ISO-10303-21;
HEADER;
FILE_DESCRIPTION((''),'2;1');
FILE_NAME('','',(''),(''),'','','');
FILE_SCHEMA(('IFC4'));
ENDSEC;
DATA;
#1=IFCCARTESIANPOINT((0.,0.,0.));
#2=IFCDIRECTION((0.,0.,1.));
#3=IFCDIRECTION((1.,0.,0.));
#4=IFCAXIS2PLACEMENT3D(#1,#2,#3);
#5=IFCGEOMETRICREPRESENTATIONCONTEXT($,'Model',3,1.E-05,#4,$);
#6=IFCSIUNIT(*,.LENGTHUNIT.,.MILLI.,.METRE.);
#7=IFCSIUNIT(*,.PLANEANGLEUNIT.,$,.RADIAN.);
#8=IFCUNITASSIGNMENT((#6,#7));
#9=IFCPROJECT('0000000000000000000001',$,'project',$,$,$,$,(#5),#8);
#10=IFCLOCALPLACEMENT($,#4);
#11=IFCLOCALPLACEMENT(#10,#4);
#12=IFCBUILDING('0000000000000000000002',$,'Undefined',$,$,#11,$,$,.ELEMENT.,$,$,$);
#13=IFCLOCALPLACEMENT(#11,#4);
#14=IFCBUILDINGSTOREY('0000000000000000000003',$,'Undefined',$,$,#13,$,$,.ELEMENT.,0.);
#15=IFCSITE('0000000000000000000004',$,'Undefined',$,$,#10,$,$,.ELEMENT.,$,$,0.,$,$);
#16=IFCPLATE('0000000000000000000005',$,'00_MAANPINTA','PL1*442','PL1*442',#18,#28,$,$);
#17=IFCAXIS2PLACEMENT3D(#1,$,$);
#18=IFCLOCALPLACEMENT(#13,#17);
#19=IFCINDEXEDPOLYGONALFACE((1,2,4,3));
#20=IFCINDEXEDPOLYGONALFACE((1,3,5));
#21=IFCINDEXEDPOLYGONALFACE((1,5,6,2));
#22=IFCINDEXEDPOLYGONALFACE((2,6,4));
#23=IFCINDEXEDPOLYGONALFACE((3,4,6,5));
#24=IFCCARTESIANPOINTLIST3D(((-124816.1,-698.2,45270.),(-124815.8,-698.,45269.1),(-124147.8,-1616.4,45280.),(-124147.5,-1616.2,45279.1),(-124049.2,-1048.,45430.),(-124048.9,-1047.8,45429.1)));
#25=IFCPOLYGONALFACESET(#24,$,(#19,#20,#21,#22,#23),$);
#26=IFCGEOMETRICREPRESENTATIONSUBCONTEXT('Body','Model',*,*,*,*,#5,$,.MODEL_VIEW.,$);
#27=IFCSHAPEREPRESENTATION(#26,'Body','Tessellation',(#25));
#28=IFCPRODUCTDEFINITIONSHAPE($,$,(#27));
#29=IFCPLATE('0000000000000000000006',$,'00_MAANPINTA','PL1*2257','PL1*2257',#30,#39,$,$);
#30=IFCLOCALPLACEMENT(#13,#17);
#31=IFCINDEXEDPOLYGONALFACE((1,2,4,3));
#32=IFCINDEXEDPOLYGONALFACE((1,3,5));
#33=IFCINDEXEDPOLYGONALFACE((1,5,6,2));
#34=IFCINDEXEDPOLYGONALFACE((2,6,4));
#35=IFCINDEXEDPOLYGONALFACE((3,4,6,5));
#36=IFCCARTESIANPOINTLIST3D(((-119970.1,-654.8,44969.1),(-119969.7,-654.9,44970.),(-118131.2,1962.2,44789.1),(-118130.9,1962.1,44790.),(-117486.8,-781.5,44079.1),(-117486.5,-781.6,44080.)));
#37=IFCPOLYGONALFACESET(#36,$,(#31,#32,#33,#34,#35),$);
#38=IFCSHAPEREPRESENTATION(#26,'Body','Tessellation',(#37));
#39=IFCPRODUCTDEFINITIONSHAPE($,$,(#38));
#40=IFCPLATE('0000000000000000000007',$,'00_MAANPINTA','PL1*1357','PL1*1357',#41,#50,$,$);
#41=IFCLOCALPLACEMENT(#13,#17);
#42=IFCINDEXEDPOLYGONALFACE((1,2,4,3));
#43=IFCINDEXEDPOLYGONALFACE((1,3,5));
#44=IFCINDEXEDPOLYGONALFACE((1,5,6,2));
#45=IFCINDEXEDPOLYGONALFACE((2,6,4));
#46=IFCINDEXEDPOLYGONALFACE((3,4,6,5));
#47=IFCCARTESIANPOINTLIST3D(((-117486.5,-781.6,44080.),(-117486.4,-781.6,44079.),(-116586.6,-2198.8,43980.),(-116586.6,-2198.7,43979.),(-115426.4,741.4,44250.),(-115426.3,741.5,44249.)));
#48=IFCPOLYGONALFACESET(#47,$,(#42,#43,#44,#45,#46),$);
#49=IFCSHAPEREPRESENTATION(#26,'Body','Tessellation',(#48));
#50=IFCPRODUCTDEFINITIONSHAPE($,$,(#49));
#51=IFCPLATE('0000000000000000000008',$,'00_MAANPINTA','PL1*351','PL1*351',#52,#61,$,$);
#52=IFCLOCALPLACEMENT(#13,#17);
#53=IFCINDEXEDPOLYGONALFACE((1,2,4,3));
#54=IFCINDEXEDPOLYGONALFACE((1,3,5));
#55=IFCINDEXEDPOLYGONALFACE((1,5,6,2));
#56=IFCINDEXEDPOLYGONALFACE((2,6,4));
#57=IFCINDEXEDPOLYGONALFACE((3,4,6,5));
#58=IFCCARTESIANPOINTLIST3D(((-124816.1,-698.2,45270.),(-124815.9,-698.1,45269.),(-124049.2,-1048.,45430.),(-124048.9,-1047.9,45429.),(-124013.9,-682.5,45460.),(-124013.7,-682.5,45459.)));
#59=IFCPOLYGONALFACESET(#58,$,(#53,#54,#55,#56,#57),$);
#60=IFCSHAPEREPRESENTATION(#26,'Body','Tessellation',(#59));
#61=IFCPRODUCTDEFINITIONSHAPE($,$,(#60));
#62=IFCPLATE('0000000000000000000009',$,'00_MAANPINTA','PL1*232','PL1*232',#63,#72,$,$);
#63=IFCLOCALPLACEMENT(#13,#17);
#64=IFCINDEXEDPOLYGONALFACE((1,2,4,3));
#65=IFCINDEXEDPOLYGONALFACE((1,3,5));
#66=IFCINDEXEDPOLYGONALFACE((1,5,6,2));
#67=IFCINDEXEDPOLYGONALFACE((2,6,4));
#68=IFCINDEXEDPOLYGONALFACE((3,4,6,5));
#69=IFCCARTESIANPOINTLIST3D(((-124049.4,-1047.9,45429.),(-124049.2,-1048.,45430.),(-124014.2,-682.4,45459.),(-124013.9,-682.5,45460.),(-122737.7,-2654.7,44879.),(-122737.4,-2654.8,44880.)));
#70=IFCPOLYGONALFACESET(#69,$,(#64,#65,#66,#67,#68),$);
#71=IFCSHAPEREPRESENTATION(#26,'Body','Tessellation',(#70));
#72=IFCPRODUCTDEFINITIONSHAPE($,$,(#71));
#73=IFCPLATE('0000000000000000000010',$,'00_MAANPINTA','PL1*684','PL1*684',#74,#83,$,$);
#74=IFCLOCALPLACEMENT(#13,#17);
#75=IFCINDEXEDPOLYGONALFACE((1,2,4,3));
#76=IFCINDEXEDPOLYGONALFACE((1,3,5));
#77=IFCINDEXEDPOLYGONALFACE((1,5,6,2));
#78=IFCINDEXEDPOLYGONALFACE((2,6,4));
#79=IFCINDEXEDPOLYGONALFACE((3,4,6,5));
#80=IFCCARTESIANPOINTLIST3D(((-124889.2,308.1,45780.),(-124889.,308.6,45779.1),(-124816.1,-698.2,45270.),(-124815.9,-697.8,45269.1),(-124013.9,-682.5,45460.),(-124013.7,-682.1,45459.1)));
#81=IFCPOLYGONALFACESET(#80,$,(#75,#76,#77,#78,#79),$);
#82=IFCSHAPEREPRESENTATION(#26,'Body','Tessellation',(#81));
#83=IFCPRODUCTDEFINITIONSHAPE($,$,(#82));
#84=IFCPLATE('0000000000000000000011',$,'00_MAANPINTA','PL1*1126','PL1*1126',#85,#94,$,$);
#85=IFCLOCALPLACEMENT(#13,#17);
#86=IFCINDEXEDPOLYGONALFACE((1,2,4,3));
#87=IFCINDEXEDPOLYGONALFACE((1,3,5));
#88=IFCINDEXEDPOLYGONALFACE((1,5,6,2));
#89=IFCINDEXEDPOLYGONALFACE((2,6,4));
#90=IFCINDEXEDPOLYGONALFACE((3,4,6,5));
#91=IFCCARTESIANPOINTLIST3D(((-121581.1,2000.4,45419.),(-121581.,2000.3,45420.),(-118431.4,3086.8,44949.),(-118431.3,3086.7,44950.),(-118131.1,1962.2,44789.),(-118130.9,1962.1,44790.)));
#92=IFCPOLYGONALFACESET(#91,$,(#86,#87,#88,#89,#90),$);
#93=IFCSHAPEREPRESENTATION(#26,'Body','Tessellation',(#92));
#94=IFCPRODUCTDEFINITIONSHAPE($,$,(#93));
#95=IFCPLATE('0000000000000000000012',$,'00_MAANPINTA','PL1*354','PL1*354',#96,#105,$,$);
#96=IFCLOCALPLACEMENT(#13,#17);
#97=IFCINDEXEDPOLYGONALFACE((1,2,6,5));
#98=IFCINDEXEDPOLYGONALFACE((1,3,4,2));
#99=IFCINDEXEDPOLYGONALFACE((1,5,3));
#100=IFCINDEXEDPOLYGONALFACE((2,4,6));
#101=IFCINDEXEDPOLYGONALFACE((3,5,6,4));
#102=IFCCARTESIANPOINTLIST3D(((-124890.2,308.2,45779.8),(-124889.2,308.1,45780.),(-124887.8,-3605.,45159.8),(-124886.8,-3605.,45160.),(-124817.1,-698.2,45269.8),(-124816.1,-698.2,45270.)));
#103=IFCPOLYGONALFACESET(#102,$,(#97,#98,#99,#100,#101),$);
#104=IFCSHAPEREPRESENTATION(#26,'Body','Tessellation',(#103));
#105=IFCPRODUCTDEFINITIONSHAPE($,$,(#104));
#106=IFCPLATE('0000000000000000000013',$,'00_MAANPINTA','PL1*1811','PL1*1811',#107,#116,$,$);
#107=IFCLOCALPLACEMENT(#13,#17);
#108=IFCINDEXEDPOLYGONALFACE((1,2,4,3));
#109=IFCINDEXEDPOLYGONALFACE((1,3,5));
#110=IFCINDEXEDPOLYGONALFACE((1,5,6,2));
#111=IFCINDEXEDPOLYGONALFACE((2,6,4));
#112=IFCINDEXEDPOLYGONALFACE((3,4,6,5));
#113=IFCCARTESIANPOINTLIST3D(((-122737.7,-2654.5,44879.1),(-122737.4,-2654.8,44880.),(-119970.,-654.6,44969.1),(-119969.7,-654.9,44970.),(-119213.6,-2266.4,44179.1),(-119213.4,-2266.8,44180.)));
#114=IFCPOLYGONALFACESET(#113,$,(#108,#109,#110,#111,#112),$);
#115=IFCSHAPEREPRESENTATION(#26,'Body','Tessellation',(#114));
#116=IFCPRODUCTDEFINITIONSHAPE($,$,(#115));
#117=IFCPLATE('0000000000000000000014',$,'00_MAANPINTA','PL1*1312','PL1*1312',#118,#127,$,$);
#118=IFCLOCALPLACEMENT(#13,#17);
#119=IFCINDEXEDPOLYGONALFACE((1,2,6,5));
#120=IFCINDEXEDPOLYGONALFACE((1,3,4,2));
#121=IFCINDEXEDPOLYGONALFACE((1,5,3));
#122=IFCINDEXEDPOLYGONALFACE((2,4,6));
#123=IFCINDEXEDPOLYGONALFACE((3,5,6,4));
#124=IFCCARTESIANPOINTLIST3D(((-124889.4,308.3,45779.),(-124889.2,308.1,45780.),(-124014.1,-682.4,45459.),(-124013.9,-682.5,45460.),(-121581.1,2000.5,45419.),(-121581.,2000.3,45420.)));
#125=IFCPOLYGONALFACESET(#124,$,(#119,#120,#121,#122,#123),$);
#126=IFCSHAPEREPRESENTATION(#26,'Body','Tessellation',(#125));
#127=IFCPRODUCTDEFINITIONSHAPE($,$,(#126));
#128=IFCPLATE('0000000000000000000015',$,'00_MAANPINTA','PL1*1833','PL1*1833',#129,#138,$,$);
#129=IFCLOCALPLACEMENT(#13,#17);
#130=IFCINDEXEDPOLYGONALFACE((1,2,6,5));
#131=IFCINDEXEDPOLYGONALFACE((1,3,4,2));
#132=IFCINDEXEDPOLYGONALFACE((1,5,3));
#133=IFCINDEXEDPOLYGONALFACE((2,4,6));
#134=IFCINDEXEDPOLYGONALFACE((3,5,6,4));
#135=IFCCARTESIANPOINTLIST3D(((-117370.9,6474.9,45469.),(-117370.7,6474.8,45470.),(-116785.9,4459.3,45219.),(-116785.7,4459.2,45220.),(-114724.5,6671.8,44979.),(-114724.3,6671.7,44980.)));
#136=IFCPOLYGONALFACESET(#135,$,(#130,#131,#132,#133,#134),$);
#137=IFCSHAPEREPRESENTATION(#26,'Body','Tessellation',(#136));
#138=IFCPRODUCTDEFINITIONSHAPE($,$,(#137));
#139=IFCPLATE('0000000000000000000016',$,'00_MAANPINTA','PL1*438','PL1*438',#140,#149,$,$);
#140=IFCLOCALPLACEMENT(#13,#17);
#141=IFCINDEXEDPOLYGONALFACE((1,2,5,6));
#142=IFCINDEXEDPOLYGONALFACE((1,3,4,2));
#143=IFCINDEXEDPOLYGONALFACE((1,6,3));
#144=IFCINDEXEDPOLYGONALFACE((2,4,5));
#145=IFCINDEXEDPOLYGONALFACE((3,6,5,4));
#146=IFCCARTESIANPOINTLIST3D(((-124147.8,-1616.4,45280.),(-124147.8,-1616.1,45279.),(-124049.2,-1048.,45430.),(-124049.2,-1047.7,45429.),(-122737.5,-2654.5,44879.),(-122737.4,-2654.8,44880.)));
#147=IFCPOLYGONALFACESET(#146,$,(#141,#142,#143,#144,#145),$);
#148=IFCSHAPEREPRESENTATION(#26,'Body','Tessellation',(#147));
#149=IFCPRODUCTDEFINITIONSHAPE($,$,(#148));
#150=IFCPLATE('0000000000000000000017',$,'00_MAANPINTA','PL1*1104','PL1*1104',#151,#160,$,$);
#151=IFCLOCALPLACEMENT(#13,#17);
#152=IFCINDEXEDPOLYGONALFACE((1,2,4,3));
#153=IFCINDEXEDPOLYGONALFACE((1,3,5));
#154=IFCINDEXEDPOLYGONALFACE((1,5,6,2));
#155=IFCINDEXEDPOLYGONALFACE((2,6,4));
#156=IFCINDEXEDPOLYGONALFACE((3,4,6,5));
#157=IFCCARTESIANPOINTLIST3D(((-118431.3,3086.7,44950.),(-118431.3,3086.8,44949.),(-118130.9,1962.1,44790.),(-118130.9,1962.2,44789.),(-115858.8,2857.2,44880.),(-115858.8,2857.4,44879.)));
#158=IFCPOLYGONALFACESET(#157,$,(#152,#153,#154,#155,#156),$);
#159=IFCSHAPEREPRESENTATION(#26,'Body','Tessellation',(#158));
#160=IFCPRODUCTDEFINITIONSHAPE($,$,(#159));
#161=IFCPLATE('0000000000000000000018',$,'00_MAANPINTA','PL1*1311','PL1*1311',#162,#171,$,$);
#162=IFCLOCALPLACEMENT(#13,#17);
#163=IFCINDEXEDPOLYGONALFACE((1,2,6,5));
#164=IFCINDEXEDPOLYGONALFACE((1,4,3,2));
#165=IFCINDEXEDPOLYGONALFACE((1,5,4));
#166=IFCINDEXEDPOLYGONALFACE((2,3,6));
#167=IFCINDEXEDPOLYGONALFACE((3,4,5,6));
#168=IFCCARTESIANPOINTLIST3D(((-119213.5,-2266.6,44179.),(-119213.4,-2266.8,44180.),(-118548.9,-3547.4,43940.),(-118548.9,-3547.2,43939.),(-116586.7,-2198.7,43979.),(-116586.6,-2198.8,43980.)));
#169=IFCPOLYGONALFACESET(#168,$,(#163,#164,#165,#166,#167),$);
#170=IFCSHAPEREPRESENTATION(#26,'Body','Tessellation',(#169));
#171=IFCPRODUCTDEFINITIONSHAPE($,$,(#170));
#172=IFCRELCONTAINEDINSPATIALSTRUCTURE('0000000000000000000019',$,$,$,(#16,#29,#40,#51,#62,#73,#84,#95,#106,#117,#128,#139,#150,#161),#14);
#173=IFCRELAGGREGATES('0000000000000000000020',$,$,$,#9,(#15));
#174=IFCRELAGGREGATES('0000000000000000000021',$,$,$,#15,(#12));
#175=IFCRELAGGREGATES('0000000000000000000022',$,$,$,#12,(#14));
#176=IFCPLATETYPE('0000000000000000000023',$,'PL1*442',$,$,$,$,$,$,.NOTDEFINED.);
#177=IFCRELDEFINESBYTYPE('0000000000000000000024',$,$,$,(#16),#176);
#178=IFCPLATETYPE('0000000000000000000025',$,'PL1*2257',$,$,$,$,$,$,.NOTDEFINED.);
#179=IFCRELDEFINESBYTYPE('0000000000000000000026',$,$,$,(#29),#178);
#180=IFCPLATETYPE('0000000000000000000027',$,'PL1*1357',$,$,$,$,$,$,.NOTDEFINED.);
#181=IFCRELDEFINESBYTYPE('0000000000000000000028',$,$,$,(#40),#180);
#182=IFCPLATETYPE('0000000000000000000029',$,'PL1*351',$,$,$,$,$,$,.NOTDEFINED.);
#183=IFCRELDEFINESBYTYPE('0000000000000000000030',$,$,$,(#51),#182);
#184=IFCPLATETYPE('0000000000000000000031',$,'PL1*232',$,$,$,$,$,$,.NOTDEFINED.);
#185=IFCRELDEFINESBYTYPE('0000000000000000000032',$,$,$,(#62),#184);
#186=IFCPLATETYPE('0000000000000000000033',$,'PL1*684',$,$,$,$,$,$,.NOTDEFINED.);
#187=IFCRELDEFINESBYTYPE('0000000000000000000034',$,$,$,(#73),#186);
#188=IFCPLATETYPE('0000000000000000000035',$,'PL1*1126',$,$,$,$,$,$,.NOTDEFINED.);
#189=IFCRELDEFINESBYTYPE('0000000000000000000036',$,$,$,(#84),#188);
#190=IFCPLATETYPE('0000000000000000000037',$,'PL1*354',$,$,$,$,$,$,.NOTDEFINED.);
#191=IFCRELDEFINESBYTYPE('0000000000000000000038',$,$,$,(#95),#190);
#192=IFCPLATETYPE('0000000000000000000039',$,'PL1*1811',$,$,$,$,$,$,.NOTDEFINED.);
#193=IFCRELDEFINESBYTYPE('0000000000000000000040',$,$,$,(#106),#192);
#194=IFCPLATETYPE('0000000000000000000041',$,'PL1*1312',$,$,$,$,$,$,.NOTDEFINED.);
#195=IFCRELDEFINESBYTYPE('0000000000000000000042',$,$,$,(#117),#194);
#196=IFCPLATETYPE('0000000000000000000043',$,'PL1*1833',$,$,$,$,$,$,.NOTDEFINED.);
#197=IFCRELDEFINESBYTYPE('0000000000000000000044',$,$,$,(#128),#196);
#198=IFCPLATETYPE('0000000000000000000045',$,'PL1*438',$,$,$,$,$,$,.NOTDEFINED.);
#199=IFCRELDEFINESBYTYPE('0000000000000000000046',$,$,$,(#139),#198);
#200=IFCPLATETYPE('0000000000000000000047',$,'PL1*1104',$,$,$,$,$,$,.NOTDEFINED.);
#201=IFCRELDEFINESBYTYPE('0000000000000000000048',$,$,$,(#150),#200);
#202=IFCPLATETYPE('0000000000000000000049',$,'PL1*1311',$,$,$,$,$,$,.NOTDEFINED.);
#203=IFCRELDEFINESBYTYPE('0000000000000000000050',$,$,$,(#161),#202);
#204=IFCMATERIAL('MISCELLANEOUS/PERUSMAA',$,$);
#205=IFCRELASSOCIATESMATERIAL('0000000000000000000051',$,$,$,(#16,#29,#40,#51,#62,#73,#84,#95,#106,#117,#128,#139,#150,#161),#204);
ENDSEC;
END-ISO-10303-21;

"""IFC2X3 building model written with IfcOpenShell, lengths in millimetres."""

from ifc_helpers import new_model, si_unit, frame, origin_with_axes, place, context, subcontext, project, spatial, polyline, outline, extrude, material, type_object, element, save


model = new_model("IFC2X3")

# Units and contexts
model_context = context("Model", 3, precision=1e-05, world=origin_with_axes())
body_context = subcontext(model_context, "Body", "Model", "MODEL_VIEW")
ifc_project = project(units=[si_unit("LENGTHUNIT", "METRE", prefix="MILLI"), si_unit("PLANEANGLEUNIT", "RADIAN")], contexts=[model_context])

# Site, building, storey
site_placement = place(None, origin_with_axes())
site = spatial("IfcSite", under=ifc_project, at=site_placement, Name="Undefined", CompositionType="ELEMENT", RefElevation=0.0)
building_placement = place(site_placement, origin_with_axes())
building = spatial("IfcBuilding", under=site, at=building_placement, Name="Undefined", CompositionType="ELEMENT")
storey_placement = place(building_placement, origin_with_axes())
storey = spatial("IfcBuildingStorey", under=building, at=storey_placement, Name="Undefined", CompositionType="ELEMENT", Elevation=0.0)

# Plates
ifc_material = material(Name="MISCELLANEOUS/PERUSMAA")
plate_type_1 = type_object("IfcPlateType", Name="PL1*442", PredefinedType="NOTDEFINED")
plate_1_placement = place(storey_placement, frame((-124147.6, -1616.3, 45279.5), z_axis=(0.285852, 0.197856, -0.937626), x_axis=(-0.588475, 0.808468, -0.008805)))
element("IfcPlate", 1, at=plate_1_placement, inside=storey, type_object=plate_type_1, material=ifc_material, Name="00_MAANPINTA", Description="PL1*442", ObjectType="PL1*442", context=body_context, shape_type="SweptSolid", body=[
    extrude(outline(polyline([(0.0, 0.0), (1135.7, 0.0), (400.2, 441.8), (0.0, 0.0)])), frame((0.0, 0.0, -0.5), z_axis=(0.0, 0.0, 1.0), x_axis=(1.0, 0.0, 0.0)), (0.0, 0.0, 1.0), 1.0),
])
plate_type_2 = type_object("IfcPlateType", Name="PL1*2257", PredefinedType="NOTDEFINED")
plate_2_placement = place(storey_placement, frame((-118131.0, 1962.2, 44789.5), z_axis=(-0.325331, 0.164549, -0.931173), x_axis=(0.221727, -0.944014, -0.244285)))
element("IfcPlate", 2, at=plate_2_placement, inside=storey, type_object=plate_type_2, material=ifc_material, Name="00_MAANPINTA", Description="PL1*2257", ObjectType="PL1*2257", context=body_context, shape_type="SweptSolid", body=[
    extrude(outline(polyline([(0.0, 0.0), (2906.4, 0.0), (2018.8, 2487.4), (0.0, 0.0)])), frame((0.0, 0.0, -0.5), z_axis=(0.0, 0.0, 1.0), x_axis=(1.0, 0.0, 0.0)), (0.0, 0.0, 1.0), 1.0),
])
plate_type_3 = type_object("IfcPlateType", Name="PL1*1357", PredefinedType="NOTDEFINED")
plate_3_placement = place(storey_placement, frame((-116586.6, -2198.8, 43979.5), z_axis=(0.02058, 0.08337, -0.996306), x_axis=(-0.535092, 0.842698, 0.059464)))
element("IfcPlate", 3, at=plate_3_placement, inside=storey, type_object=plate_type_3, material=ifc_material, Name="00_MAANPINTA", Description="PL1*1357", ObjectType="PL1*1357", context=body_context, shape_type="SweptSolid", body=[
    extrude(outline(polyline([(0.0, 0.0), (1681.7, 0.0), (1872.9, 2560.5), (0.0, 0.0)])), frame((0.0, 0.0, -0.5), z_axis=(0.0, 0.0, 1.0), x_axis=(1.0, 0.0, 0.0)), (0.0, 0.0, 1.0), 1.0),
])
plate_type_4 = type_object("IfcPlateType", Name="PL1*351", PredefinedType="NOTDEFINED")
plate_4_placement = place(storey_placement, frame((-124049.1, -1047.9, 45429.5), z_axis=(0.229033, 0.057682, -0.971708), x_axis=(-0.893881, 0.407675, -0.186488)))
element("IfcPlate", 4, at=plate_4_placement, inside=storey, type_object=plate_type_4, material=ifc_material, Name="00_MAANPINTA", Description="PL1*351", ObjectType="PL1*351", context=body_context, shape_type="SweptSolid", body=[
    extrude(outline(polyline([(0.0, 0.0), (858.0, 0.0), (111.9, 351.0), (0.0, 0.0)])), frame((0.0, 0.0, -0.5), z_axis=(0.0, 0.0, 1.0), x_axis=(1.0, 0.0, 0.0)), (0.0, 0.0, 1.0), 1.0),
])
plate_type_5 = type_object("IfcPlateType", Name="PL1*232", PredefinedType="NOTDEFINED")
plate_5_placement = place(storey_placement, frame((-122737.6, -2654.7, 44879.5), z_axis=(-0.272636, 0.104799, -0.956393), x_axis=(-0.611261, 0.748779, 0.2563)))
element("IfcPlate", 5, at=plate_5_placement, inside=storey, type_object=plate_type_5, material=ifc_material, Name="00_MAANPINTA", Description="PL1*232", ObjectType="PL1*232", context=body_context, shape_type="SweptSolid", body=[
    extrude(outline(polyline([(0.0, 0.0), (2145.9, 0.0), (2405.7, 261.2), (0.0, 0.0)])), frame((0.0, 0.0, -0.5), z_axis=(0.0, 0.0, 1.0), x_axis=(1.0, 0.0, 0.0)), (0.0, 0.0, 1.0), 1.0),
])
plate_type_6 = type_object("IfcPlateType", Name="PL1*684", PredefinedType="NOTDEFINED")
plate_6_placement = place(storey_placement, frame((-124013.8, -682.3, 45459.6), z_axis=(0.196871, 0.454548, -0.868693), x_axis=(-0.9729, -0.019025, -0.230443)))
element("IfcPlate", 6, at=plate_6_placement, inside=storey, type_object=plate_type_6, material=ifc_material, Name="00_MAANPINTA", Description="PL1*684", ObjectType="PL1*684", context=body_context, shape_type="SweptSolid", body=[
    extrude(outline(polyline([(0.0, 0.0), (824.5, 0.0), (759.0, 1128.7), (0.0, 0.0)])), frame((0.0, 0.0, -0.5), z_axis=(0.0, 0.0, 1.0), x_axis=(1.0, 0.0, 0.0)), (0.0, 0.0, 1.0), 1.0),
])
plate_type_7 = type_object("IfcPlateType", Name="PL1*1126", PredefinedType="NOTDEFINED")
plate_7_placement = place(storey_placement, frame((-118431.3, 3086.7, 44949.5), z_axis=(-0.177888, 0.091882, -0.979752), x_axis=(0.255642, -0.957133, -0.136176)))
element("IfcPlate", 7, at=plate_7_placement, inside=storey, type_object=plate_type_7, material=ifc_material, Name="00_MAANPINTA", Description="PL1*1126", ObjectType="PL1*1126", context=body_context, shape_type="SweptSolid", body=[
    extrude(outline(polyline([(0.0, 0.0), (1174.9, 0.0), (170.6, 3360.4), (0.0, 0.0)])), frame((0.0, 0.0, -0.5), z_axis=(0.0, 0.0, 1.0), x_axis=(1.0, 0.0, 0.0)), (0.0, 0.0, 1.0), 1.0),
])
plate_type_8 = type_object("IfcPlateType", Name="PL1*354", PredefinedType="NOTDEFINED")
plate_8_placement = place(storey_placement, frame((-124889.7, 308.2, 45779.9), z_axis=(-0.978778, 0.031465, -0.202495), x_axis=(0.06471, -0.890125, -0.451098)))
element("IfcPlate", 8, at=plate_8_placement, inside=storey, type_object=plate_type_8, material=ifc_material, Name="00_MAANPINTA", Description="PL1*354", ObjectType="PL1*354", context=body_context, shape_type="SweptSolid", body=[
    extrude(outline(polyline([(0.0, 0.0), (1130.6, 0.0), (3763.0, 1239.6), (0.0, 0.0)])), frame((0.0, 0.0, -0.5), z_axis=(0.0, 0.0, 1.0), x_axis=(1.0, 0.0, 0.0)), (0.0, 0.0, 1.0), 1.0),
])
plate_type_9 = type_object("IfcPlateType", Name="PL1*1811", PredefinedType="NOTDEFINED")
plate_9_placement = place(storey_placement, frame((-119969.9, -654.8, 44969.5), z_axis=(-0.219256, 0.344515, -0.912818), x_axis=(0.388283, -0.827492, -0.405576)))
element("IfcPlate", 9, at=plate_9_placement, inside=storey, type_object=plate_type_9, material=ifc_material, Name="00_MAANPINTA", Description="PL1*1811", ObjectType="PL1*1811", context=body_context, shape_type="SweptSolid", body=[
    extrude(outline(polyline([(0.0, 0.0), (1947.8, 0.0), (616.7, 3359.7), (0.0, 0.0)])), frame((0.0, 0.0, -0.5), z_axis=(0.0, 0.0, 1.0), x_axis=(1.0, 0.0, 0.0)), (0.0, 0.0, 1.0), 1.0),
])
plate_type_10 = type_object("IfcPlateType", Name="PL1*1312", PredefinedType="NOTDEFINED")
plate_10_placement = place(storey_placement, frame((-124014.0, -682.4, 45459.5), z_axis=(-0.183317, 0.151762, -0.971269), x_axis=(-0.643545, 0.728353, 0.235269)))
element("IfcPlate", 10, at=plate_10_placement, inside=storey, type_object=plate_type_10, material=ifc_material, Name="00_MAANPINTA", Description="PL1*1312", ObjectType="PL1*1312", context=body_context, shape_type="SweptSolid", body=[
    extrude(outline(polyline([(0.0, 0.0), (1360.1, 0.0), (378.9, 3602.1), (0.0, 0.0)])), frame((0.0, 0.0, -0.5), z_axis=(0.0, 0.0, 1.0), x_axis=(1.0, 0.0, 0.0)), (0.0, 0.0, 1.0), 1.0),
])
plate_type_11 = type_object("IfcPlateType", Name="PL1*1833", PredefinedType="NOTDEFINED")
plate_11_placement = place(storey_placement, frame((-116785.8, 4459.3, 45219.5), z_axis=(-0.186498, 0.067446, -0.980138), x_axis=(-0.276753, 0.953634, 0.118282)))
element("IfcPlate", 11, at=plate_11_placement, inside=storey, type_object=plate_type_11, material=ifc_material, Name="00_MAANPINTA", Description="PL1*1833", ObjectType="PL1*1833", context=body_context, shape_type="SweptSolid", body=[
    extrude(outline(polyline([(0.0, 0.0), (2113.6, 0.0), (1511.0, 2630.4), (0.0, 0.0)])), frame((0.0, 0.0, -0.5), z_axis=(0.0, 0.0, 1.0), x_axis=(1.0, 0.0, 0.0)), (0.0, 0.0, 1.0), 1.0),
])
plate_type_12 = type_object("IfcPlateType", Name="PL1*438", PredefinedType="NOTDEFINED")
plate_12_placement = place(storey_placement, frame((-124049.2, -1047.8, 45429.5), z_axis=(-0.076092, 0.266741, -0.96076), x_axis=(0.611261, -0.748779, -0.2563)))
element("IfcPlate", 12, at=plate_12_placement, inside=storey, type_object=plate_type_12, material=ifc_material, Name="00_MAANPINTA", Description="PL1*438", ObjectType="PL1*438", context=body_context, shape_type="SweptSolid", body=[
    extrude(outline(polyline([(0.0, 0.0), (2145.9, 0.0), (403.8, 438.5), (0.0, 0.0)])), frame((0.0, 0.0, -0.5), z_axis=(0.0, 0.0, 1.0), x_axis=(1.0, 0.0, 0.0)), (0.0, 0.0, 1.0), 1.0),
])
plate_type_13 = type_object("IfcPlateType", Name="PL1*1104", PredefinedType="NOTDEFINED")
plate_13_placement = place(storey_placement, frame((-118130.9, 1962.1, 44789.5), z_axis=(-0.014734, 0.136983, -0.990464), x_axis=(-0.255642, 0.957133, 0.136176)))
element("IfcPlate", 13, at=plate_13_placement, inside=storey, type_object=plate_type_13, material=ifc_material, Name="00_MAANPINTA", Description="PL1*1104", ObjectType="PL1*1104", context=body_context, shape_type="SweptSolid", body=[
    extrude(outline(polyline([(0.0, 0.0), (1174.9, 0.0), (288.2, 2426.7), (0.0, 0.0)])), frame((0.0, 0.0, -0.5), z_axis=(0.0, 0.0, 1.0), x_axis=(1.0, 0.0, 0.0)), (0.0, 0.0, 1.0), 1.0),
])
plate_type_14 = type_object("IfcPlateType", Name="PL1*1311", PredefinedType="NOTDEFINED")
plate_14_placement = place(storey_placement, frame((-118548.9, -3547.3, 43939.5), z_axis=(-0.078828, 0.143958, -0.986439), x_axis=(-0.454365, 0.875573, 0.164087)))
element("IfcPlate", 14, at=plate_14_placement, inside=storey, type_object=plate_type_14, material=ifc_material, Name="00_MAANPINTA", Description="PL1*1311", ObjectType="PL1*1311", context=body_context, shape_type="SweptSolid", body=[
    extrude(outline(polyline([(0.0, 0.0), (1462.6, 0.0), (295.8, 2362.9), (0.0, 0.0)])), frame((0.0, 0.0, -0.5), z_axis=(0.0, 0.0, 1.0), x_axis=(1.0, 0.0, 0.0)), (0.0, 0.0, 1.0), 1.0),
])

save(model, "model.ifc")
